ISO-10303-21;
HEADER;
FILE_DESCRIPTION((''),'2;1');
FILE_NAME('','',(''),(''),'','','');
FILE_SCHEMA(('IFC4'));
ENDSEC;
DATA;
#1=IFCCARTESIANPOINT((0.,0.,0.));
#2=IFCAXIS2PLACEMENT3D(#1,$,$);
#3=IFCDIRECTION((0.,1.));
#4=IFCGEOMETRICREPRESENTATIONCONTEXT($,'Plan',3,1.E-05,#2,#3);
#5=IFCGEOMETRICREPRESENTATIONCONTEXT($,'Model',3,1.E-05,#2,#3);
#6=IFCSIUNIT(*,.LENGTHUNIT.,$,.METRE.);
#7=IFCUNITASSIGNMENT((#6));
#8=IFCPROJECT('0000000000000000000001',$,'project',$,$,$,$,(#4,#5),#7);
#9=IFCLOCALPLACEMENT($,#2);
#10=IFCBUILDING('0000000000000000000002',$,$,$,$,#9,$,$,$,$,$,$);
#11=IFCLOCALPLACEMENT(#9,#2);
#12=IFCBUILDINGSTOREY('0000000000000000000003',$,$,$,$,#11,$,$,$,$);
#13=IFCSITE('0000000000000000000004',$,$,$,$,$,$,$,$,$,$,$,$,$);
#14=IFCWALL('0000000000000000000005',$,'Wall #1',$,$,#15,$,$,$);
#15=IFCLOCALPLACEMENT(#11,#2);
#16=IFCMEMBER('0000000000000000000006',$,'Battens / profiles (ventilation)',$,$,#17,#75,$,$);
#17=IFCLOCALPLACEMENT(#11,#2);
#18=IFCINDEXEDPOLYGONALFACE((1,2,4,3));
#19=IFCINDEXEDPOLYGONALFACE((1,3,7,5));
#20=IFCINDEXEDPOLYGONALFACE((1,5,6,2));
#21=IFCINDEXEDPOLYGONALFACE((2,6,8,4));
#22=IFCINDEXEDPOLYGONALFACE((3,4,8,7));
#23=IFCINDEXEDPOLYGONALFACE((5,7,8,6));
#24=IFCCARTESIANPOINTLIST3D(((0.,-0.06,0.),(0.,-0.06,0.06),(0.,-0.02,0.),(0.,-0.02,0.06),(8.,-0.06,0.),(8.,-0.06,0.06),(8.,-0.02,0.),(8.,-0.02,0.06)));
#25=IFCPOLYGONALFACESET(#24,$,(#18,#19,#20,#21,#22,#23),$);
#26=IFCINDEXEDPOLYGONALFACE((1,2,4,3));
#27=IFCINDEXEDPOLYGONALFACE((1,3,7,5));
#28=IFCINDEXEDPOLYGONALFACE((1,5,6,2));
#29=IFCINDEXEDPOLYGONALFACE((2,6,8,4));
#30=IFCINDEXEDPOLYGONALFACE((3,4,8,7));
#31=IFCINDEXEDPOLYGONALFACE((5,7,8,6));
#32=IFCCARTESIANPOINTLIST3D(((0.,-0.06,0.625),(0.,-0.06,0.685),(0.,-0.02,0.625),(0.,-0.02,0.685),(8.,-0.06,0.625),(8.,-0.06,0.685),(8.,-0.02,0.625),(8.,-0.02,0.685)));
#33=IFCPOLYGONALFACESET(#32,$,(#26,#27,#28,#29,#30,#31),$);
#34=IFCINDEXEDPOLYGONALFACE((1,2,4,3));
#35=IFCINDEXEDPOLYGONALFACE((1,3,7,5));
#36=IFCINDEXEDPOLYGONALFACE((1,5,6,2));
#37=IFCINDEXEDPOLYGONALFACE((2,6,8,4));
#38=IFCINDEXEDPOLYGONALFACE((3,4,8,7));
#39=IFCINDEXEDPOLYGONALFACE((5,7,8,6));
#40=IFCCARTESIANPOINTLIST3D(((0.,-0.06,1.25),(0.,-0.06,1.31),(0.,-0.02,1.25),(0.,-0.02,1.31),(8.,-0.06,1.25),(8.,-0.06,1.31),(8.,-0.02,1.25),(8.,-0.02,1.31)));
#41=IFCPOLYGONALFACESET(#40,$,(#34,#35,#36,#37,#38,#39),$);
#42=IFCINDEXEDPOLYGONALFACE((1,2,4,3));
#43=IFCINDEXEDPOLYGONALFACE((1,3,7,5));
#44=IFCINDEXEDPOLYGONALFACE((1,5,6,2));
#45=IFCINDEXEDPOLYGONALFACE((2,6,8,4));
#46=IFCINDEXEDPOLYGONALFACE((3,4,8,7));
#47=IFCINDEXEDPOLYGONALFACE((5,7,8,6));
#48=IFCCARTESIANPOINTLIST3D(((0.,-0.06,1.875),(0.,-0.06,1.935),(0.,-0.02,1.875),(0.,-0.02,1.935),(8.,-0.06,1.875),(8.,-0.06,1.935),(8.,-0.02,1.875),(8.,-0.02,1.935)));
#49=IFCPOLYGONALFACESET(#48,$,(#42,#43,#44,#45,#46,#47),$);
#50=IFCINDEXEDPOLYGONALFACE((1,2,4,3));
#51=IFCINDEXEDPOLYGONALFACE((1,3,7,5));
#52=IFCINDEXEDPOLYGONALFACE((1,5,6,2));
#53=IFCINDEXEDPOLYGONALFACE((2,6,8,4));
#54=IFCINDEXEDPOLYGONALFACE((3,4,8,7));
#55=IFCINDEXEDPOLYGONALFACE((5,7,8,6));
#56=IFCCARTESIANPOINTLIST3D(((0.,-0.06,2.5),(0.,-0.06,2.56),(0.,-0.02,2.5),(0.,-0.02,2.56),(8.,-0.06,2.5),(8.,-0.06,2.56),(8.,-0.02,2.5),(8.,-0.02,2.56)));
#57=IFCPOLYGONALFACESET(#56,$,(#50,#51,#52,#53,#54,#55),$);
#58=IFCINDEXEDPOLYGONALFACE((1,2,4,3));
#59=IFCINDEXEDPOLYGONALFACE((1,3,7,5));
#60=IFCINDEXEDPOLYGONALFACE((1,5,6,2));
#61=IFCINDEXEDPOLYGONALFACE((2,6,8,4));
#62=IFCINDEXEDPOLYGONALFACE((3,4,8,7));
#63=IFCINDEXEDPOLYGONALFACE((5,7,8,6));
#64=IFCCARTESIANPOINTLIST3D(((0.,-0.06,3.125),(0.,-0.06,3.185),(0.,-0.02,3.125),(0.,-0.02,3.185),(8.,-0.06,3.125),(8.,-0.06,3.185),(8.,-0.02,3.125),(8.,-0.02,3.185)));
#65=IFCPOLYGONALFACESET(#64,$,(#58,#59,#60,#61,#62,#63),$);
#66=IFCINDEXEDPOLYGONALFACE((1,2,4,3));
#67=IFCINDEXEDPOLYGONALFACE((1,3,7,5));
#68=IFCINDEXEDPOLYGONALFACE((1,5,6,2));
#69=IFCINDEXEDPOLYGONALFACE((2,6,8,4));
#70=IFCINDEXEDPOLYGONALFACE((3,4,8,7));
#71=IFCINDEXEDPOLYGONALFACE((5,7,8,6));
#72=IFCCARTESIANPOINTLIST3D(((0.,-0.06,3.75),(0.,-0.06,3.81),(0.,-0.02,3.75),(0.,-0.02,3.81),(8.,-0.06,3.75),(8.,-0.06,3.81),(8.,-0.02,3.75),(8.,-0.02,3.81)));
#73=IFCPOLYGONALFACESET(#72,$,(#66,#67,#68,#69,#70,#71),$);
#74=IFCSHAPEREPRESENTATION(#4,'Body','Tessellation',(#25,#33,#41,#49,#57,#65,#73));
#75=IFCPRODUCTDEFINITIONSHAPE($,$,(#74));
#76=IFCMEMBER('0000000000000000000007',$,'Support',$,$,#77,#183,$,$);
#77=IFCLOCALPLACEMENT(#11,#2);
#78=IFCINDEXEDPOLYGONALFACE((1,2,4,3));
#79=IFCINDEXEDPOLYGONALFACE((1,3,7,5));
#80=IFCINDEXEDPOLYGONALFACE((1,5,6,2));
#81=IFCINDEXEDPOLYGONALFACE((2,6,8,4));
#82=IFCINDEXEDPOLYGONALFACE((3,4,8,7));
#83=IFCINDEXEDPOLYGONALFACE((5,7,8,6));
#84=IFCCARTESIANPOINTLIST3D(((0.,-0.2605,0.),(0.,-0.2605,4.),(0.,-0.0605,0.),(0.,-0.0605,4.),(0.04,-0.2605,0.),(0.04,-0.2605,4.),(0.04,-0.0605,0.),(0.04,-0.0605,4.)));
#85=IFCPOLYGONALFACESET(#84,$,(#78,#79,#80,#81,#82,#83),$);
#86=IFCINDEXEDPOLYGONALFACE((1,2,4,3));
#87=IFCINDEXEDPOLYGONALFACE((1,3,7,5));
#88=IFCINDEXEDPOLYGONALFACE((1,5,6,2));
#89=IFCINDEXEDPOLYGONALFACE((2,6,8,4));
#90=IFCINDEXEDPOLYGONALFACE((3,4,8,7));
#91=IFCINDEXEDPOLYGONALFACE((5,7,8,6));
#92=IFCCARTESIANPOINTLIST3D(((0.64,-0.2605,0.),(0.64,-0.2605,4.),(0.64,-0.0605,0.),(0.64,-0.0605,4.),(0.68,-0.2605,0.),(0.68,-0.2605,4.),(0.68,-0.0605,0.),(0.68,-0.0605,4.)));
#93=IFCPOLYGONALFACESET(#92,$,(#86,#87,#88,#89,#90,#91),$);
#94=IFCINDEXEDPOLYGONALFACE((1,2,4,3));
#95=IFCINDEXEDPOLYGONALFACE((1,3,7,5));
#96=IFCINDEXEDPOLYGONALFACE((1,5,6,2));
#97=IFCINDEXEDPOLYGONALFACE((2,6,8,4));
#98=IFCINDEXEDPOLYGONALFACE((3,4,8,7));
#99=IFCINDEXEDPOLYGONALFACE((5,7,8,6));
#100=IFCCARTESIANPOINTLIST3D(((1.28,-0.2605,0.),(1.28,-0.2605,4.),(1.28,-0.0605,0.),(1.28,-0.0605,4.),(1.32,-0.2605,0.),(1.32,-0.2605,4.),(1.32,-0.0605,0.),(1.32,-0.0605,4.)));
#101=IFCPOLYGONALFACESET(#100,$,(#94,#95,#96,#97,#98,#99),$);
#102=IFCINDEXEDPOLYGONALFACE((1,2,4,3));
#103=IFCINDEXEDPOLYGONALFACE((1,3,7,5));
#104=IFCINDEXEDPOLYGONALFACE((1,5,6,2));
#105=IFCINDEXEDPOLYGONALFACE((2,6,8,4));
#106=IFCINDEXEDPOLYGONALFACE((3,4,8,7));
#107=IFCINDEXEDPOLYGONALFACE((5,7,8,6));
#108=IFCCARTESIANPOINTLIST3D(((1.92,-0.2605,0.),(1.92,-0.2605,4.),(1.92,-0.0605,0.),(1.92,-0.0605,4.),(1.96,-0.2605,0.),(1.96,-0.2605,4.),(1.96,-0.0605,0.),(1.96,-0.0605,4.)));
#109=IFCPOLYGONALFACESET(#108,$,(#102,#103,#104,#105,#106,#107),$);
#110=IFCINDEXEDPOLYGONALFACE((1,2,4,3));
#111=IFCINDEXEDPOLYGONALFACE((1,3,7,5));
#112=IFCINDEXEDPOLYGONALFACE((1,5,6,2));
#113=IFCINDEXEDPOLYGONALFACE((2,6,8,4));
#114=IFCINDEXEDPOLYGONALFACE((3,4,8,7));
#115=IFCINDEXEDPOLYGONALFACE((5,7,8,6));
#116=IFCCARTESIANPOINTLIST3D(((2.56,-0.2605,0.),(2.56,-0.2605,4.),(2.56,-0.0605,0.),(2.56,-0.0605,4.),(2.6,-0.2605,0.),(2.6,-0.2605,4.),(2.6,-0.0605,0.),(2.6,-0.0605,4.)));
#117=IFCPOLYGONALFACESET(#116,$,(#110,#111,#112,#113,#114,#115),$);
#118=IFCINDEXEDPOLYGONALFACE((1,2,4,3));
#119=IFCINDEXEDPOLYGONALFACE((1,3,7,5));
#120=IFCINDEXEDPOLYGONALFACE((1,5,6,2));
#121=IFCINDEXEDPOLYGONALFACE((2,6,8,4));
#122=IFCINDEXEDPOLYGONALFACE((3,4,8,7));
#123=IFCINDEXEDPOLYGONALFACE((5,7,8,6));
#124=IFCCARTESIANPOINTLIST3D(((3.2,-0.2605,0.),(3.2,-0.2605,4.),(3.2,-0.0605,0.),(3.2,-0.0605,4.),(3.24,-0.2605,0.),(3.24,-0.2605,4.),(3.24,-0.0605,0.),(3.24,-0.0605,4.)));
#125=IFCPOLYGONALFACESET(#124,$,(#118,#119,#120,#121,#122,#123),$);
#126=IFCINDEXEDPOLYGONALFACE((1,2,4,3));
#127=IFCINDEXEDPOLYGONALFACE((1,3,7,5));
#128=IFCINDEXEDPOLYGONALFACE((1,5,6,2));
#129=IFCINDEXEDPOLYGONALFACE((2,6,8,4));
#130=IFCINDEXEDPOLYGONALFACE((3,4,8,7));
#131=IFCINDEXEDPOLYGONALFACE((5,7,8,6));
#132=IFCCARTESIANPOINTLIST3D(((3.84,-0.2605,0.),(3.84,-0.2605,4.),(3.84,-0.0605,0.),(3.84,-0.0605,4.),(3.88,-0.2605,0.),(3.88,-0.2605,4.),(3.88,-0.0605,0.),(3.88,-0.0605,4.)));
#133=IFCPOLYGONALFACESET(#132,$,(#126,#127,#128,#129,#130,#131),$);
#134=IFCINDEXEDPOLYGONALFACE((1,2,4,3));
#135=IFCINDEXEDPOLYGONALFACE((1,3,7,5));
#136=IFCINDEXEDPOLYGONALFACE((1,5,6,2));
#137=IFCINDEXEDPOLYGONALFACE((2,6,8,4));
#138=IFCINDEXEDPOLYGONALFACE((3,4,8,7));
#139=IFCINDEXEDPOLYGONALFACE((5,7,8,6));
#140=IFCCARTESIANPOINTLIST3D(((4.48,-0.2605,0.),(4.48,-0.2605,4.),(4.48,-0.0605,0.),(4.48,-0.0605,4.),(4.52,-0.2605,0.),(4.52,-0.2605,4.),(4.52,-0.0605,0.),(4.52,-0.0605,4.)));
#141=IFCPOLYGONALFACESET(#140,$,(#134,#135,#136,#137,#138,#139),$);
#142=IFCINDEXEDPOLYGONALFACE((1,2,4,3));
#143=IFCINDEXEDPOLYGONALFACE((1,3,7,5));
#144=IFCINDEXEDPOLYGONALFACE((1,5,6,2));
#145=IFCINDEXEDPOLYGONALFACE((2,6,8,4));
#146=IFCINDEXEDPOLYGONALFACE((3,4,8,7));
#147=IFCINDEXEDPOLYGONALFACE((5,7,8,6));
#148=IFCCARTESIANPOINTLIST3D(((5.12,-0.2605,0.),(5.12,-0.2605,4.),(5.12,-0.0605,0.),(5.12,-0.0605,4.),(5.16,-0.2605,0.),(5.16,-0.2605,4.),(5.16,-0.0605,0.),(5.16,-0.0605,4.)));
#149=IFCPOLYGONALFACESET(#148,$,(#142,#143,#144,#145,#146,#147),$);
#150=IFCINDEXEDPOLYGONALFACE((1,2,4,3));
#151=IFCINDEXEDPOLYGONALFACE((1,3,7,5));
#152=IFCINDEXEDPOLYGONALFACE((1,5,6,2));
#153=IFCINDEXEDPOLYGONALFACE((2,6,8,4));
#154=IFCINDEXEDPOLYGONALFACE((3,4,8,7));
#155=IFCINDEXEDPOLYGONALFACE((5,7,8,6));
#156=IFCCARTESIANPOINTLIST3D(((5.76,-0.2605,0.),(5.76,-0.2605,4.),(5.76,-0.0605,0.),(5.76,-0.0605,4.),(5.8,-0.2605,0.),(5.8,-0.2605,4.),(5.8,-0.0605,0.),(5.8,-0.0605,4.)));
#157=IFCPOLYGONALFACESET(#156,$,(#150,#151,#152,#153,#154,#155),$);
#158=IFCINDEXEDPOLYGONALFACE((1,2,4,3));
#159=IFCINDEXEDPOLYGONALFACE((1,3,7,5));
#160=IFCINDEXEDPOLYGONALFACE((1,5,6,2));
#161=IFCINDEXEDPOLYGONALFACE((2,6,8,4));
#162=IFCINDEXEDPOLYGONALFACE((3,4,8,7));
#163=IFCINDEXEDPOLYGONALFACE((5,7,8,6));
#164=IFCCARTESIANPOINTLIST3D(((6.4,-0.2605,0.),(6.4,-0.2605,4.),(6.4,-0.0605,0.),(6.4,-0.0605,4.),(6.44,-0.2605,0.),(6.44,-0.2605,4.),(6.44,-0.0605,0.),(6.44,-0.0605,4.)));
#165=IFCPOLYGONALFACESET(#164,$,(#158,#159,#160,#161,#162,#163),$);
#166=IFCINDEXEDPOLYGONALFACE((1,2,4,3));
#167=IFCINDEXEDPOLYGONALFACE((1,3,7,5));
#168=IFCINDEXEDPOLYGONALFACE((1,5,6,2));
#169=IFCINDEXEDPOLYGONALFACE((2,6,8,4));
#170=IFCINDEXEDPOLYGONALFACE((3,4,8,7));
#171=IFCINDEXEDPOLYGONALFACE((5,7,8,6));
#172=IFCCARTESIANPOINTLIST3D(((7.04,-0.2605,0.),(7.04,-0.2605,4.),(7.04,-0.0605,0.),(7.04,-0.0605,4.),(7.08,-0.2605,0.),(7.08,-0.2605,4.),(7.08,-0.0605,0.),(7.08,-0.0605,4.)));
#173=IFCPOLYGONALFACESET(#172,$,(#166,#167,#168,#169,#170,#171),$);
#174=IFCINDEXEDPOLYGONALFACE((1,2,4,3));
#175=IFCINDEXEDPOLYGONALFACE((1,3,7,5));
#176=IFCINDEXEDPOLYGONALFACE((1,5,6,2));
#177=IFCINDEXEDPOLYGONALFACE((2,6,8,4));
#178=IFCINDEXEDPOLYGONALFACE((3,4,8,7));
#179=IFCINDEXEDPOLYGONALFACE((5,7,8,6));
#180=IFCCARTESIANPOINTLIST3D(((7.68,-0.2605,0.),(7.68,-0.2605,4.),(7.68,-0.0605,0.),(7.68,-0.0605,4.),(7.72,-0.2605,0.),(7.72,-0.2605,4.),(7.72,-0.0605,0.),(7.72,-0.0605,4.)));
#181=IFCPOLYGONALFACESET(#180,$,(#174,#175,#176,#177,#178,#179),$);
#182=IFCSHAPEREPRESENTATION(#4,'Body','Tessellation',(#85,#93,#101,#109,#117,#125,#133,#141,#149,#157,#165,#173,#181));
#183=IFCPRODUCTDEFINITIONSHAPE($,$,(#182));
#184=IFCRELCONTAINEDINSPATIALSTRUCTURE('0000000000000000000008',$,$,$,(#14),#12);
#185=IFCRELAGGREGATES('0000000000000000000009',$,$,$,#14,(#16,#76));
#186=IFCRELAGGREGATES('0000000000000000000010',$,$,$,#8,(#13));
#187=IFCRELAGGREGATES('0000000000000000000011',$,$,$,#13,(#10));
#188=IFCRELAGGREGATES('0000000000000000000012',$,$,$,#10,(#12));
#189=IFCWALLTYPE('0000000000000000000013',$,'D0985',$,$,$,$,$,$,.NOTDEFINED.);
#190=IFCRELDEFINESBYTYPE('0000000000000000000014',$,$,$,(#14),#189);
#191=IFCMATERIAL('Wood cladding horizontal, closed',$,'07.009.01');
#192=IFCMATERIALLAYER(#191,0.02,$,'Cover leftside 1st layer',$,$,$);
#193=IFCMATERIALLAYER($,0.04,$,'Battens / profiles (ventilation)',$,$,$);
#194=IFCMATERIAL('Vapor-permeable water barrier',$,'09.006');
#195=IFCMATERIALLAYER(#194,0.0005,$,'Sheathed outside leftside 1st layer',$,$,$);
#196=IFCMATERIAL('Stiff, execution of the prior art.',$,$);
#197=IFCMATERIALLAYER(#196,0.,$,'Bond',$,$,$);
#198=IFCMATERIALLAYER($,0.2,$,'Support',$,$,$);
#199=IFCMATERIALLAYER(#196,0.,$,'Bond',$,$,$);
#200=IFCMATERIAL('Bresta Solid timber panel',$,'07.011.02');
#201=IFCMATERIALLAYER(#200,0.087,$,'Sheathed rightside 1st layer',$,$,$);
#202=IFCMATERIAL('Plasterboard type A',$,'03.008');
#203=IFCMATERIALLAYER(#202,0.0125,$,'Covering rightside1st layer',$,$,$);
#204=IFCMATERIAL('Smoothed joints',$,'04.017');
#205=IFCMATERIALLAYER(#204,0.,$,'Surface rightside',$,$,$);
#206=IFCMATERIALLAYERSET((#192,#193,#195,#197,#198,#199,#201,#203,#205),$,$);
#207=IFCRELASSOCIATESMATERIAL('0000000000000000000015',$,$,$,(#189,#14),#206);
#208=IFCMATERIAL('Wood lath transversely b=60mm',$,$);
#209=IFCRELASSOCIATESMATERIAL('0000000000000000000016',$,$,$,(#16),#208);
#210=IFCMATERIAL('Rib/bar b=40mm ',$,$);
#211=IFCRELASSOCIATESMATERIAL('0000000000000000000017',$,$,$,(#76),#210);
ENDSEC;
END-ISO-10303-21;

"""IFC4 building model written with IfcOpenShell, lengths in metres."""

from ifc_helpers import new_model, si_unit, direction, frame, frame_2d, origin, place, context, project, spatial, rectangle, extrude, material, layer, layer_set, type_object, element, aggregate, save


model = new_model("IFC4")

# Units and contexts
plan_context = context("Plan", 3, precision=1e-05, world=origin(), true_north=direction((0.0, 1.0)))
model_context = context("Model", 3, precision=1e-05, world=origin(), true_north=direction((0.0, 1.0)))
ifc_project = project(units=[si_unit("LENGTHUNIT", "METRE")], contexts=[plan_context, model_context])

# Site, building, storey
site = spatial("IfcSite", under=ifc_project)
building_placement = place(None, origin())
building = spatial("IfcBuilding", under=site, at=building_placement)
storey_placement = place(building_placement, origin())
storey = spatial("IfcBuildingStorey", under=building, at=storey_placement)

# Wall, members
ifc_material_1 = material(Name="Wood cladding horizontal, closed", Category="07.009.01")
ifc_layer_1 = layer(ifc_material_1, 0.02, Name="Cover leftside 1st layer")
ifc_layer_2 = layer(None, 0.04, Name="Battens / profiles (ventilation)")
ifc_material_2 = material(Name="Vapor-permeable water barrier", Category="09.006")
ifc_layer_3 = layer(ifc_material_2, 0.0005, Name="Sheathed outside leftside 1st layer")
ifc_material_3 = material(Name="Stiff, execution of the prior art.")
ifc_layer_4 = layer(ifc_material_3, 0.0, Name="Bond")
ifc_layer_5 = layer(None, 0.2, Name="Support")
ifc_layer_6 = layer(ifc_material_3, 0.0, Name="Bond")
ifc_material_4 = material(Name="Bresta Solid timber panel", Category="07.011.02")
ifc_layer_7 = layer(ifc_material_4, 0.087, Name="Sheathed rightside 1st layer")
ifc_material_5 = material(Name="Plasterboard type A", Category="03.008")
ifc_layer_8 = layer(ifc_material_5, 0.0125, Name="Covering rightside1st layer")
ifc_material_6 = material(Name="Smoothed joints", Category="04.017")
ifc_layer_9 = layer(ifc_material_6, 0.0, Name="Surface rightside")
ifc_layer_set = layer_set([ifc_layer_1, ifc_layer_2, ifc_layer_3, ifc_layer_4, ifc_layer_5, ifc_layer_6, ifc_layer_7, ifc_layer_8, ifc_layer_9])
wall_type = type_object("IfcWallType", Name="D0985", PredefinedType="NOTDEFINED", material=ifc_layer_set)
wall_placement = place(None, frame((0.0, 0.0, 0.0), z_axis=(0.0, -1.0, 0.0), x_axis=(1.0, 0.0, 0.0)))
wall = element("IfcWall", 1, at=wall_placement, inside=storey, type_object=wall_type, material=ifc_layer_set, Name="Wall #1")
ifc_material_7 = material(Name="Wood lath transversely b=60mm")
member_1_placement = place(wall_placement, origin())
member_1 = element("IfcMember", 2, at=member_1_placement, material=ifc_material_7, Name="Battens / profiles (ventilation)", context=plan_context, shape_type="SweptSolid", body=[
    extrude(rectangle(XDim=0.06, YDim=0.04, at=frame_2d((0.03, 0.02), x_axis=(1.0, 0.0))), frame((0.0, 0.0, 0.02), z_axis=(1.0, 0.0, 0.0), x_axis=(0.0, 1.0, 0.0)), (0.0, 0.0, 1.0), 8.0),
    extrude(rectangle(XDim=0.06, YDim=0.04, at=frame_2d((0.03, 0.02), x_axis=(1.0, 0.0))), frame((0.0, 0.625, 0.02), z_axis=(1.0, 0.0, 0.0), x_axis=(0.0, 1.0, 0.0)), (0.0, 0.0, 1.0), 8.0),
    extrude(rectangle(XDim=0.06, YDim=0.04, at=frame_2d((0.03, 0.02), x_axis=(1.0, 0.0))), frame((0.0, 1.25, 0.02), z_axis=(1.0, 0.0, 0.0), x_axis=(0.0, 1.0, 0.0)), (0.0, 0.0, 1.0), 8.0),
    extrude(rectangle(XDim=0.06, YDim=0.04, at=frame_2d((0.03, 0.02), x_axis=(1.0, 0.0))), frame((0.0, 1.875, 0.02), z_axis=(1.0, 0.0, 0.0), x_axis=(0.0, 1.0, 0.0)), (0.0, 0.0, 1.0), 8.0),
    extrude(rectangle(XDim=0.06, YDim=0.04, at=frame_2d((0.03, 0.02), x_axis=(1.0, 0.0))), frame((0.0, 2.5, 0.02), z_axis=(1.0, 0.0, 0.0), x_axis=(0.0, 1.0, 0.0)), (0.0, 0.0, 1.0), 8.0),
    extrude(rectangle(XDim=0.06, YDim=0.04, at=frame_2d((0.03, 0.02), x_axis=(1.0, 0.0))), frame((0.0, 3.125, 0.02), z_axis=(1.0, 0.0, 0.0), x_axis=(0.0, 1.0, 0.0)), (0.0, 0.0, 1.0), 8.0),
    extrude(rectangle(XDim=0.06, YDim=0.04, at=frame_2d((0.03, 0.02), x_axis=(1.0, 0.0))), frame((0.0, 3.75, 0.02), z_axis=(1.0, 0.0, 0.0), x_axis=(0.0, 1.0, 0.0)), (0.0, 0.0, 1.0), 8.0),
])
ifc_material_8 = material(Name="Rib/bar b=40mm ")
member_2_placement = place(wall_placement, origin())
member_2 = element("IfcMember", 3, at=member_2_placement, material=ifc_material_8, Name="Support", context=plan_context, shape_type="SweptSolid", body=[
    extrude(rectangle(XDim=0.04, YDim=0.2, at=frame_2d((0.02, 0.1), x_axis=(1.0, 0.0))), frame((0.0, 4.0, 0.0605), z_axis=(0.0, -1.0, 0.0), x_axis=(1.0, 0.0, 0.0)), (0.0, 0.0, 1.0), 4.0),
    extrude(rectangle(XDim=0.04, YDim=0.2, at=frame_2d((0.02, 0.1), x_axis=(1.0, 0.0))), frame((0.64, 4.0, 0.0605), z_axis=(0.0, -1.0, 0.0), x_axis=(1.0, 0.0, 0.0)), (0.0, 0.0, 1.0), 4.0),
    extrude(rectangle(XDim=0.04, YDim=0.2, at=frame_2d((0.02, 0.1), x_axis=(1.0, 0.0))), frame((1.28, 4.0, 0.0605), z_axis=(0.0, -1.0, 0.0), x_axis=(1.0, 0.0, 0.0)), (0.0, 0.0, 1.0), 4.0),
    extrude(rectangle(XDim=0.04, YDim=0.2, at=frame_2d((0.02, 0.1), x_axis=(1.0, 0.0))), frame((1.92, 4.0, 0.0605), z_axis=(0.0, -1.0, 0.0), x_axis=(1.0, 0.0, 0.0)), (0.0, 0.0, 1.0), 4.0),
    extrude(rectangle(XDim=0.04, YDim=0.2, at=frame_2d((0.02, 0.1), x_axis=(1.0, 0.0))), frame((2.56, 4.0, 0.0605), z_axis=(0.0, -1.0, 0.0), x_axis=(1.0, 0.0, 0.0)), (0.0, 0.0, 1.0), 4.0),
    extrude(rectangle(XDim=0.04, YDim=0.2, at=frame_2d((0.02, 0.1), x_axis=(1.0, 0.0))), frame((3.2, 4.0, 0.0605), z_axis=(0.0, -1.0, 0.0), x_axis=(1.0, 0.0, 0.0)), (0.0, 0.0, 1.0), 4.0),
    extrude(rectangle(XDim=0.04, YDim=0.2, at=frame_2d((0.02, 0.1), x_axis=(1.0, 0.0))), frame((3.84, 4.0, 0.0605), z_axis=(0.0, -1.0, 0.0), x_axis=(1.0, 0.0, 0.0)), (0.0, 0.0, 1.0), 4.0),
    extrude(rectangle(XDim=0.04, YDim=0.2, at=frame_2d((0.02, 0.1), x_axis=(1.0, 0.0))), frame((4.48, 4.0, 0.0605), z_axis=(0.0, -1.0, 0.0), x_axis=(1.0, 0.0, 0.0)), (0.0, 0.0, 1.0), 4.0),
    extrude(rectangle(XDim=0.04, YDim=0.2, at=frame_2d((0.02, 0.1), x_axis=(1.0, 0.0))), frame((5.12, 4.0, 0.0605), z_axis=(0.0, -1.0, 0.0), x_axis=(1.0, 0.0, 0.0)), (0.0, 0.0, 1.0), 4.0),
    extrude(rectangle(XDim=0.04, YDim=0.2, at=frame_2d((0.02, 0.1), x_axis=(1.0, 0.0))), frame((5.76, 4.0, 0.0605), z_axis=(0.0, -1.0, 0.0), x_axis=(1.0, 0.0, 0.0)), (0.0, 0.0, 1.0), 4.0),
    extrude(rectangle(XDim=0.04, YDim=0.2, at=frame_2d((0.02, 0.1), x_axis=(1.0, 0.0))), frame((6.4, 4.0, 0.0605), z_axis=(0.0, -1.0, 0.0), x_axis=(1.0, 0.0, 0.0)), (0.0, 0.0, 1.0), 4.0),
    extrude(rectangle(XDim=0.04, YDim=0.2, at=frame_2d((0.02, 0.1), x_axis=(1.0, 0.0))), frame((7.04, 4.0, 0.0605), z_axis=(0.0, -1.0, 0.0), x_axis=(1.0, 0.0, 0.0)), (0.0, 0.0, 1.0), 4.0),
    extrude(rectangle(XDim=0.04, YDim=0.2, at=frame_2d((0.02, 0.1), x_axis=(1.0, 0.0))), frame((7.68, 4.0, 0.0605), z_axis=(0.0, -1.0, 0.0), x_axis=(1.0, 0.0, 0.0)), (0.0, 0.0, 1.0), 4.0),
])
aggregate(wall, [member_1, member_2])

save(model, "model.ifc")
